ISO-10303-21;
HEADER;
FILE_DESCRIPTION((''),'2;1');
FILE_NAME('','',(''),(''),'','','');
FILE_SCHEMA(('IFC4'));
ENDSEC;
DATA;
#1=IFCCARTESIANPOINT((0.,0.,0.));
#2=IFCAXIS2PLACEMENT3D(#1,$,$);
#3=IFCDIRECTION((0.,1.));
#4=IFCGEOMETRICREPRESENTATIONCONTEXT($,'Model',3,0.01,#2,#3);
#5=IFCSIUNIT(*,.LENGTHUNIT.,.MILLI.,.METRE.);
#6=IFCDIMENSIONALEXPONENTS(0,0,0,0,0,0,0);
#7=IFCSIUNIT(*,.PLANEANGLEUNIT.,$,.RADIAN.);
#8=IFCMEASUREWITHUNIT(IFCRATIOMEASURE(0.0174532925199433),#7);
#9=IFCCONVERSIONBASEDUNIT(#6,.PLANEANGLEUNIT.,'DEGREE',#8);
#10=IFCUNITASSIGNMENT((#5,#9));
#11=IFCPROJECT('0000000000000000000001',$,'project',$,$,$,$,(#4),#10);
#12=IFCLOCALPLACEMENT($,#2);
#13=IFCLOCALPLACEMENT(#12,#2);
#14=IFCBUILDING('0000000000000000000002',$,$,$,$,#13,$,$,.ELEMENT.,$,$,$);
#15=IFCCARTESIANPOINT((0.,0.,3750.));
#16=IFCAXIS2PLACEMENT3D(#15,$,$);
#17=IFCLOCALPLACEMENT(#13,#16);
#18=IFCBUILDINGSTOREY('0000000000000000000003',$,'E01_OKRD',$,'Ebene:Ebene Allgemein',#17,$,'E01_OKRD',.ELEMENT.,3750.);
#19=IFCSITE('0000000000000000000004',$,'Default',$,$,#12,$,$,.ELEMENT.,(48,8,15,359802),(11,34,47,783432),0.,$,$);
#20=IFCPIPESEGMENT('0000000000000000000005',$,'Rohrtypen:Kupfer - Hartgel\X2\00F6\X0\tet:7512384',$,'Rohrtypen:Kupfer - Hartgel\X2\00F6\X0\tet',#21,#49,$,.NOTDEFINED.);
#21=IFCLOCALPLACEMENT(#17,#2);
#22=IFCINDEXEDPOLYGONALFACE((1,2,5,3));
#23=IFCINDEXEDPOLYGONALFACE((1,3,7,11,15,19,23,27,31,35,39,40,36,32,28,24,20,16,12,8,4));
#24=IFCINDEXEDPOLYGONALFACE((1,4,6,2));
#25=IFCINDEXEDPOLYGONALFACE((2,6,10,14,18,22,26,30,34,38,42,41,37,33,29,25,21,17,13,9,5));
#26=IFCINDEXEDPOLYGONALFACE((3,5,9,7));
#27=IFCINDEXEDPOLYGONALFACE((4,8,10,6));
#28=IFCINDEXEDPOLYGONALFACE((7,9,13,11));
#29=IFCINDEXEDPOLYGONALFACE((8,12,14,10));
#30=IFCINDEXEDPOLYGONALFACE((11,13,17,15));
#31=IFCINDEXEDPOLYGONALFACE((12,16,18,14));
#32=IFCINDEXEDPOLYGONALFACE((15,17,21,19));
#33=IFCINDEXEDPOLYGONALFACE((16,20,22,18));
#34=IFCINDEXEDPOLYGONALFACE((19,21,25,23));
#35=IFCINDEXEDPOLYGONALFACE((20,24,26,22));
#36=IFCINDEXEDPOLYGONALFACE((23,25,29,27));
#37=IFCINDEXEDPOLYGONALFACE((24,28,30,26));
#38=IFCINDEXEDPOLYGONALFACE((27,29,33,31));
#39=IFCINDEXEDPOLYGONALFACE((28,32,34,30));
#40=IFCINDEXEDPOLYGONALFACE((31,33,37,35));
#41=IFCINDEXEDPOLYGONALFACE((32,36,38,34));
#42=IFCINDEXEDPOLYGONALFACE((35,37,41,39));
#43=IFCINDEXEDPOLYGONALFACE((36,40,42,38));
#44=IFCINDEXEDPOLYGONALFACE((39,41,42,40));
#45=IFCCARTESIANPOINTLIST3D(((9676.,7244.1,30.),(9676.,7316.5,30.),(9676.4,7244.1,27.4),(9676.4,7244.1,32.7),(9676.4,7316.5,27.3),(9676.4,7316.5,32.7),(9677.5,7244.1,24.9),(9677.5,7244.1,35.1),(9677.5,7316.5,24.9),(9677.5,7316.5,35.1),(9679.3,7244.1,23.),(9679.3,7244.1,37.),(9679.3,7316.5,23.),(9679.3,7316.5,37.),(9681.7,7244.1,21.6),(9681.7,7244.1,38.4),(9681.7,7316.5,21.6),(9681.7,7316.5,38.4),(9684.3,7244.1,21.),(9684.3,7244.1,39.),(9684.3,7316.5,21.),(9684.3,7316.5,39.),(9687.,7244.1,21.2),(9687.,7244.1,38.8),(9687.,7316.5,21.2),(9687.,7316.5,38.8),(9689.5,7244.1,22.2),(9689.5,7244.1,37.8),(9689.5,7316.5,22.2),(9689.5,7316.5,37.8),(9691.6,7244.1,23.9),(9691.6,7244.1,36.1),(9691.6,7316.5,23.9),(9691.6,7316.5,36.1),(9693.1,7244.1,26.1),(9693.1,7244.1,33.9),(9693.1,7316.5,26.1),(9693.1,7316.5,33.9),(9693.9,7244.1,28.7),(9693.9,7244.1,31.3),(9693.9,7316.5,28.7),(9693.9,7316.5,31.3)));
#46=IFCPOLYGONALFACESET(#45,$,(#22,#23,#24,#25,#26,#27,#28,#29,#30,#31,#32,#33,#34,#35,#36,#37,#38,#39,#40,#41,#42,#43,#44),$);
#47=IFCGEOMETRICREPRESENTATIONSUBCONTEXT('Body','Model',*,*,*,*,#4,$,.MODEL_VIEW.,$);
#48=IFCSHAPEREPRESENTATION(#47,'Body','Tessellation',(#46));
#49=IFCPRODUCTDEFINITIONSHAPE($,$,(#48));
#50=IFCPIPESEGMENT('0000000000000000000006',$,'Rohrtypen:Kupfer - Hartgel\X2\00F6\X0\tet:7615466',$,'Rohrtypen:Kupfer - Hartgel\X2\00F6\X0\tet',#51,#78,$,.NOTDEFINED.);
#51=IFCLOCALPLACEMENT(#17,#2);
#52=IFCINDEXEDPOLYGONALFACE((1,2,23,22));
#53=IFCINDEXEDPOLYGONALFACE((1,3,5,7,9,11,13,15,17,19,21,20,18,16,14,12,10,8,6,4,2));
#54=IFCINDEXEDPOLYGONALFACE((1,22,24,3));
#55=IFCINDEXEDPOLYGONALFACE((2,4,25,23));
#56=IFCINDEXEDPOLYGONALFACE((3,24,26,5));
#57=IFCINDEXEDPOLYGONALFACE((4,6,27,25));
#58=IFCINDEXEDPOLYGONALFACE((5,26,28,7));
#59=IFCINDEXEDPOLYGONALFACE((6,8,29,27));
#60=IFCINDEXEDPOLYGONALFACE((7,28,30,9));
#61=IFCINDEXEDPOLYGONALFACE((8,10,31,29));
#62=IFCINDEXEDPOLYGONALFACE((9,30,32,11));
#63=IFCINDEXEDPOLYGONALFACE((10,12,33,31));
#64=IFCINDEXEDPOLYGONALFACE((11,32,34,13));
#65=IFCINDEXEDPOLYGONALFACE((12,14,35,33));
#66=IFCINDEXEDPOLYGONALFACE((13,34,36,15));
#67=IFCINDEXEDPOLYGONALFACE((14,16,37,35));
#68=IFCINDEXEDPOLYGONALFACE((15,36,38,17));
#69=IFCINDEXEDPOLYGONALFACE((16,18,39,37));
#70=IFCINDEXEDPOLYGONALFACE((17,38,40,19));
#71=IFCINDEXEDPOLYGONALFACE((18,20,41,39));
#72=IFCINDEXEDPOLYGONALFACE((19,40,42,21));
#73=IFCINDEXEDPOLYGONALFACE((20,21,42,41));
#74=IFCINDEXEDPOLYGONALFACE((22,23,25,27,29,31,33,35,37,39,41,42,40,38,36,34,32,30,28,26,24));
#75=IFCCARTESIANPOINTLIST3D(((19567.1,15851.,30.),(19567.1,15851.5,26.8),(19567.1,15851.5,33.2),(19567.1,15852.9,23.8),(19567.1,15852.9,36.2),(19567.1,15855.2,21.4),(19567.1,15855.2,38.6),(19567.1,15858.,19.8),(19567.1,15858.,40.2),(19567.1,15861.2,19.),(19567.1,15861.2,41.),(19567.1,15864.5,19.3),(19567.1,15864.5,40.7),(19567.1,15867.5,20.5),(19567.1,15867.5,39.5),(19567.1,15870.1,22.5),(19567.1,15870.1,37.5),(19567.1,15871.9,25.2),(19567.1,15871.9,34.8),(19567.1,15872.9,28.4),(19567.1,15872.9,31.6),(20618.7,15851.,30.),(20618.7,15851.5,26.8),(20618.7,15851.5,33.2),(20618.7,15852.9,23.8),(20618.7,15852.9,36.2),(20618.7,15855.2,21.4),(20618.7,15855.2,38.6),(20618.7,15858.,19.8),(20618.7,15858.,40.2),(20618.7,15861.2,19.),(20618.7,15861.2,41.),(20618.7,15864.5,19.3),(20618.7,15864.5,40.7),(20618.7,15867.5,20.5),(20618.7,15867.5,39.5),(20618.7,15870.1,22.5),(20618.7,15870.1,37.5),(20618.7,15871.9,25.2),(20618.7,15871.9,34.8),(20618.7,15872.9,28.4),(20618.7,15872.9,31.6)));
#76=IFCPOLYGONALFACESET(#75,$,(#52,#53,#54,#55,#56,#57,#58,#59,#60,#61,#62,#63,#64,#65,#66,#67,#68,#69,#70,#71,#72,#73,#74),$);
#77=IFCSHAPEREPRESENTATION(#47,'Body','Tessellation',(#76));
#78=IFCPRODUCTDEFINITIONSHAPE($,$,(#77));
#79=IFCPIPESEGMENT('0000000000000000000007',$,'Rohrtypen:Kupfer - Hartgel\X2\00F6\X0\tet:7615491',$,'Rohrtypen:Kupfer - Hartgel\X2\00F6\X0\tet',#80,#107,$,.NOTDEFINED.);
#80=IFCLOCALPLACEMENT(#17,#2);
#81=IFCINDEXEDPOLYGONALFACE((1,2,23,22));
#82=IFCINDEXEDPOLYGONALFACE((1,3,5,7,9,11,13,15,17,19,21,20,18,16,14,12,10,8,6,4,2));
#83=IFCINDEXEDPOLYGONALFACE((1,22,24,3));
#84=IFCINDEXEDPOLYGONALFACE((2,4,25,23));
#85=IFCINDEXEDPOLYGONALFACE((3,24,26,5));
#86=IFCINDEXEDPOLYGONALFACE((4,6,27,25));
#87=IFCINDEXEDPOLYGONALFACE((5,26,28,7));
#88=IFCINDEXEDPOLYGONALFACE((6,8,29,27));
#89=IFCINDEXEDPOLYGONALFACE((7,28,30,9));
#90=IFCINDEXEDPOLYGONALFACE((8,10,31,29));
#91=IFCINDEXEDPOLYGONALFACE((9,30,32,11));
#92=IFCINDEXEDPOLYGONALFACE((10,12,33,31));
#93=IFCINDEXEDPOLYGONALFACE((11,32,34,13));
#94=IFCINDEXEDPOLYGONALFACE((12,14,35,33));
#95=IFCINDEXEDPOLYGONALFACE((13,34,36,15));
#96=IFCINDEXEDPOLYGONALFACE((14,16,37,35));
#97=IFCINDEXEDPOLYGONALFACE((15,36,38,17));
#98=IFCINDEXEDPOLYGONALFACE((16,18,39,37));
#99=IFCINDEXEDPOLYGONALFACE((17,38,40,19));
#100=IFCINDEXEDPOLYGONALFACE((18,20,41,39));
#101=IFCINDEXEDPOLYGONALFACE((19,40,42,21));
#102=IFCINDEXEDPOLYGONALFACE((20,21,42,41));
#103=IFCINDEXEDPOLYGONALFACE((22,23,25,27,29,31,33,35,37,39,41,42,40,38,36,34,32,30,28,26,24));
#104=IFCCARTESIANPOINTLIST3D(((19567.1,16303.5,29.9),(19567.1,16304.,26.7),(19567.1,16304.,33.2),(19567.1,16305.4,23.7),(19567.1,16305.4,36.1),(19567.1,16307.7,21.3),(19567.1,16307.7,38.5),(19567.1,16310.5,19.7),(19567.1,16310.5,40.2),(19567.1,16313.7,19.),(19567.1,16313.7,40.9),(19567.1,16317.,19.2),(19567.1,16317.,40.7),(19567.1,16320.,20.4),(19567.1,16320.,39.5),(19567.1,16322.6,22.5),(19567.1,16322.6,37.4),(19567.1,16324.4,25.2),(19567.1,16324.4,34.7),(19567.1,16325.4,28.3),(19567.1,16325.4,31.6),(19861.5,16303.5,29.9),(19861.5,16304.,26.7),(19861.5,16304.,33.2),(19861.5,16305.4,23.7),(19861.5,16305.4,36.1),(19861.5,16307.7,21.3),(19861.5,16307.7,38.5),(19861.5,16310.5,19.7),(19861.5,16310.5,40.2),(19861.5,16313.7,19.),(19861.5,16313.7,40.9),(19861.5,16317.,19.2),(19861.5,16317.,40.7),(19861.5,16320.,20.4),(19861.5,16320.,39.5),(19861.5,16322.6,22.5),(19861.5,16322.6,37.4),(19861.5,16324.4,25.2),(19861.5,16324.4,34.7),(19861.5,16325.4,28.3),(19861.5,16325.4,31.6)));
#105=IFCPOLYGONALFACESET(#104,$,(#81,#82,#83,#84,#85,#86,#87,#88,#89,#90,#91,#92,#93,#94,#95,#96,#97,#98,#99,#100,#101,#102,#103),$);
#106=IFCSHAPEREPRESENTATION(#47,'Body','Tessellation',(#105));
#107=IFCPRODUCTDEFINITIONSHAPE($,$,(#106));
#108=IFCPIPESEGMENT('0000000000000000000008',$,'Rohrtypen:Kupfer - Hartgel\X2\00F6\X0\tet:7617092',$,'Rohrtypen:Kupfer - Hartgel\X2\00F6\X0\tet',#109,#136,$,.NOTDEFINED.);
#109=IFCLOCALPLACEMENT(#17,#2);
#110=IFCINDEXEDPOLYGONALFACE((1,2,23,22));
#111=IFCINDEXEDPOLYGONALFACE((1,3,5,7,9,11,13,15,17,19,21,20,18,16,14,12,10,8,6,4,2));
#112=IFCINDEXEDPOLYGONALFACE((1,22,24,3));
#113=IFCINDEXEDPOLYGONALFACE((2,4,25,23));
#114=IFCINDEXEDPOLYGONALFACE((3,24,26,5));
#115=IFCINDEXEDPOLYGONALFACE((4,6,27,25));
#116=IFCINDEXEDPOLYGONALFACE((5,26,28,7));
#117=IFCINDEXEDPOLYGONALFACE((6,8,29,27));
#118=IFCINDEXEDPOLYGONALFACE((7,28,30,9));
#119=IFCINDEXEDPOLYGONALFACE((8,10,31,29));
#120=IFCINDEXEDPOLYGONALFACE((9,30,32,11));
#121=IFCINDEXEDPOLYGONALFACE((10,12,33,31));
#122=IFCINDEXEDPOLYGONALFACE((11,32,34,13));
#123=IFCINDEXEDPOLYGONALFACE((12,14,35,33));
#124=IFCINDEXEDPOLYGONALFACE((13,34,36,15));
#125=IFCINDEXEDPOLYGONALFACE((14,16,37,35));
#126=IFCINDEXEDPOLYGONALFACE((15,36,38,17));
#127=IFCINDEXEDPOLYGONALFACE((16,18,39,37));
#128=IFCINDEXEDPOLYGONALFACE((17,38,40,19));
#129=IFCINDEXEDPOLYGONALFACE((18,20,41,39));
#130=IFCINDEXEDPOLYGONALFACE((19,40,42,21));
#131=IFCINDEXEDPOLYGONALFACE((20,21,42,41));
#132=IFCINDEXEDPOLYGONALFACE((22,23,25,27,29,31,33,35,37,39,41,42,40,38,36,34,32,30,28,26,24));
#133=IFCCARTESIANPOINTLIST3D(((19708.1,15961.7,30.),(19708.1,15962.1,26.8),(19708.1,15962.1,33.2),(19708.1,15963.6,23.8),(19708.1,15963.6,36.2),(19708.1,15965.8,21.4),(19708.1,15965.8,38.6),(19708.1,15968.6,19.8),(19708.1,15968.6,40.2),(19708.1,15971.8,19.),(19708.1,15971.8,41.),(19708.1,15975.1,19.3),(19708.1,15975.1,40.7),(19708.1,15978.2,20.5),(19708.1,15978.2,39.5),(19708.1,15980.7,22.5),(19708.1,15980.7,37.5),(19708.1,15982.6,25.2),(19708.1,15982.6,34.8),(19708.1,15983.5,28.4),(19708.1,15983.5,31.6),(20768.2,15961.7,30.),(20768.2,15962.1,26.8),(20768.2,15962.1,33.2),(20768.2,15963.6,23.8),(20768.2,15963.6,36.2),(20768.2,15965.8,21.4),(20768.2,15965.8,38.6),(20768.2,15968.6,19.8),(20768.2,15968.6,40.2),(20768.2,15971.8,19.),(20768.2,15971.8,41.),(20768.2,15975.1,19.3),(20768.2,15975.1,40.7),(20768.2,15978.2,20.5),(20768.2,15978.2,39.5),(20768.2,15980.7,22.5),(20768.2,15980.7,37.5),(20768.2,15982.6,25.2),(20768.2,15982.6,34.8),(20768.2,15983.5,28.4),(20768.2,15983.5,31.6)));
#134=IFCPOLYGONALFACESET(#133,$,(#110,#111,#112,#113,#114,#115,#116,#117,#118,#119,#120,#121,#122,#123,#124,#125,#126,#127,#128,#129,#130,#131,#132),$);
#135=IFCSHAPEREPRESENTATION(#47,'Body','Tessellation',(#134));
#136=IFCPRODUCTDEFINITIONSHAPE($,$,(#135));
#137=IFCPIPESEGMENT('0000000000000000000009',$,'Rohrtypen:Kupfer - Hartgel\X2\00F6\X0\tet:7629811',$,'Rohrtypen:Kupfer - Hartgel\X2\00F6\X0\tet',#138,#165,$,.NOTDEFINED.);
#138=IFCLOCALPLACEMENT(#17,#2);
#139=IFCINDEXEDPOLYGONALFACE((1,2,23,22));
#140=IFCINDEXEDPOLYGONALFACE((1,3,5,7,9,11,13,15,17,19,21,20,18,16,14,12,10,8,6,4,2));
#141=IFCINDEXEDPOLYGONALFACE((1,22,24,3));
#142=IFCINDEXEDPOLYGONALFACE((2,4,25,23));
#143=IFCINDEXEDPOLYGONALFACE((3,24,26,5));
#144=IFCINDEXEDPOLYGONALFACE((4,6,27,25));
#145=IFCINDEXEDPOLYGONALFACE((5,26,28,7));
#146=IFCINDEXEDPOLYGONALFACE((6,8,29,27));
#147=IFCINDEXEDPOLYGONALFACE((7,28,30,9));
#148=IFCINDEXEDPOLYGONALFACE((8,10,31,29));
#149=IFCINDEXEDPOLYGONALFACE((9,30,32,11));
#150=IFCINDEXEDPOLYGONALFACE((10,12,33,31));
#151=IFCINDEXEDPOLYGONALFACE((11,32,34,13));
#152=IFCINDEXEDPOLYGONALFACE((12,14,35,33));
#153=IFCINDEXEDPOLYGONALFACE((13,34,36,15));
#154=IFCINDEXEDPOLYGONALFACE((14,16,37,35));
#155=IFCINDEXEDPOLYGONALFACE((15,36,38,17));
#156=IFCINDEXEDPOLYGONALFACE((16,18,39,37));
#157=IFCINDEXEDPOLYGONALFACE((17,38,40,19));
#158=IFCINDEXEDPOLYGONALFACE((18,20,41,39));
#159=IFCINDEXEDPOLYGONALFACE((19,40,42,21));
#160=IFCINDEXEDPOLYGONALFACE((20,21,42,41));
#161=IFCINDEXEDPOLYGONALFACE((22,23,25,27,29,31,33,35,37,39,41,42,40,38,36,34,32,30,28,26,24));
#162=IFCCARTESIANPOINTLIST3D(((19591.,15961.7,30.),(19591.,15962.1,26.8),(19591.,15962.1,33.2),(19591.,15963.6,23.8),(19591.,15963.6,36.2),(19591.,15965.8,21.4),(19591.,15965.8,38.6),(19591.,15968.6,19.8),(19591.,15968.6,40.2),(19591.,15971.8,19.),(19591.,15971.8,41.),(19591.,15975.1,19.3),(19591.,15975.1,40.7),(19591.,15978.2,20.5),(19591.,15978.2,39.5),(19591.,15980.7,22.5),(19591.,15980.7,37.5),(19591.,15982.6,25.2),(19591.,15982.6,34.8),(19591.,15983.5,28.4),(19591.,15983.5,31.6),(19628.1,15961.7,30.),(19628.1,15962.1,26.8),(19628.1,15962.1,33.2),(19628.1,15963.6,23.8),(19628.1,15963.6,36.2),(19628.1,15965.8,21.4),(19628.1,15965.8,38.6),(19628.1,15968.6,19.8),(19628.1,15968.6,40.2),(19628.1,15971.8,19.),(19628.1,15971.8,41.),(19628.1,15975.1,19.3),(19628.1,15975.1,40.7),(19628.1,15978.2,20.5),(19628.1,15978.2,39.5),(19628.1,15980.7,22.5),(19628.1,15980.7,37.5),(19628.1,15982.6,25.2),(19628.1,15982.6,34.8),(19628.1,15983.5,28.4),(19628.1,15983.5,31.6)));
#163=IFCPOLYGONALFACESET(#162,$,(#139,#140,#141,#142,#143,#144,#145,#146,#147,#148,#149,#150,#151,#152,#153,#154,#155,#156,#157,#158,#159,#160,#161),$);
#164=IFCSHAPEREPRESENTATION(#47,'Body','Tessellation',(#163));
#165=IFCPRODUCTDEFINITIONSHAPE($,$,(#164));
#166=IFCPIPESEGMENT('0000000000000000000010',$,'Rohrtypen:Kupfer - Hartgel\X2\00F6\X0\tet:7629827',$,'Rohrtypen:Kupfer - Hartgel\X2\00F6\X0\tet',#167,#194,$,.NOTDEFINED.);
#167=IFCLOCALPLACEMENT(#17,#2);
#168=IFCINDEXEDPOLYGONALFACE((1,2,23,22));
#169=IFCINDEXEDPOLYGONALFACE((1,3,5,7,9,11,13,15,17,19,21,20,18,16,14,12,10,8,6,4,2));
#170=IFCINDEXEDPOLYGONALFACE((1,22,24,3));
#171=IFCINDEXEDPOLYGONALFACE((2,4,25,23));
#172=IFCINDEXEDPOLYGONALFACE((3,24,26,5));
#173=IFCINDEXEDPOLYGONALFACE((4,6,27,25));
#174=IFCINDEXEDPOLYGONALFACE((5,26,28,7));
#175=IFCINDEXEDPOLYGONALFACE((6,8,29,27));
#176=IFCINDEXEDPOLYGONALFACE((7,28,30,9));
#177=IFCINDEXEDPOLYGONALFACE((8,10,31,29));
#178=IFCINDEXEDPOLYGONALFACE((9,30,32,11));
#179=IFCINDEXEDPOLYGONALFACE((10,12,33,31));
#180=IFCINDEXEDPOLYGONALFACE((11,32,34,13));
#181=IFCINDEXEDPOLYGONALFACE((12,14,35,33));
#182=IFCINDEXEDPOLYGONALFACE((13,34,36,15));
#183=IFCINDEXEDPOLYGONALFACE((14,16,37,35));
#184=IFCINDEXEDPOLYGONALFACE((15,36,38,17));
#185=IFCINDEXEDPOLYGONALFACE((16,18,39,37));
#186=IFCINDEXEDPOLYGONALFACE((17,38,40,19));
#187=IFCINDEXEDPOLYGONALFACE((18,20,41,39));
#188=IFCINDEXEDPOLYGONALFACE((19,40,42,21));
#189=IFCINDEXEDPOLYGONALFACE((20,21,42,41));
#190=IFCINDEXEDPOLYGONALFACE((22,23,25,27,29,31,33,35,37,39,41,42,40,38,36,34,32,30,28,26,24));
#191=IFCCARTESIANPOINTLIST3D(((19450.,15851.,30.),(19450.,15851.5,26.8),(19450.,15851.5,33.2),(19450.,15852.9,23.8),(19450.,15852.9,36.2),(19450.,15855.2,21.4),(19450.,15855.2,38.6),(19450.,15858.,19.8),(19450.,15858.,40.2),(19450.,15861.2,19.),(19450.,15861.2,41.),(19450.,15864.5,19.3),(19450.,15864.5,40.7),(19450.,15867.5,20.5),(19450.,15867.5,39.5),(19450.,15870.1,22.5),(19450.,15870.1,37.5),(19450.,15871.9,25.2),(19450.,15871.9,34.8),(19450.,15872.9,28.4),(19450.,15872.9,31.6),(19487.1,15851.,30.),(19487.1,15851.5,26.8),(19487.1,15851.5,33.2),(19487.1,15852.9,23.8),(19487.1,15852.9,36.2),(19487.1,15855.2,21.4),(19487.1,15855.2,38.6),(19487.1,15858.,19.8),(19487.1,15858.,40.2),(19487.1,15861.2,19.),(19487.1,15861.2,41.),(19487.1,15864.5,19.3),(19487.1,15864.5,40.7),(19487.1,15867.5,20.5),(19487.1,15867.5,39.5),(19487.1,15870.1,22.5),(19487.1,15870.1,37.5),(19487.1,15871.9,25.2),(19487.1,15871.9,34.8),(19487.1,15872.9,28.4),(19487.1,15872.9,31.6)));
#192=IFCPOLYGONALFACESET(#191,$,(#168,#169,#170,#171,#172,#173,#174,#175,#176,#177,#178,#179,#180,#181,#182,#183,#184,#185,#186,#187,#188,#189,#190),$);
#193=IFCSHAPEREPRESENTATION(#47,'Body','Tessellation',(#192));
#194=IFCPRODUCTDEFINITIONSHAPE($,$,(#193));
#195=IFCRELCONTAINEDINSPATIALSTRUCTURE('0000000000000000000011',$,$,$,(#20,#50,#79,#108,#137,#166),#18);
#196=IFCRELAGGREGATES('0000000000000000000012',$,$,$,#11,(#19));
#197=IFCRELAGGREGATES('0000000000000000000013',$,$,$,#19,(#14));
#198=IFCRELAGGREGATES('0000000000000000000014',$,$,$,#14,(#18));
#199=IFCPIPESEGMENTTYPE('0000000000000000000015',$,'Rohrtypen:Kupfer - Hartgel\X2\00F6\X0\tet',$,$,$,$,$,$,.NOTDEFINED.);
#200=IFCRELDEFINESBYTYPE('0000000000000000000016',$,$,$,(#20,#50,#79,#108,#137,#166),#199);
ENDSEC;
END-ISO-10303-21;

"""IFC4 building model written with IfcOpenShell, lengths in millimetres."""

from ifc_helpers import new_model, entity, si_unit, converted_unit, direction, frame, frame_2d, origin, origin_2d_with_axis, place, context, subcontext, project, spatial, circle, extrude, type_object, element, save


model = new_model("IFC4")

# Units and contexts
model_context = context("Model", 3, precision=0.01, world=origin(), true_north=direction((0.0, 1.0)))
body_context = subcontext(model_context, "Body", "Model", "MODEL_VIEW")
ifc_project = project(units=[si_unit("LENGTHUNIT", "METRE", prefix="MILLI"), converted_unit("PLANEANGLEUNIT", "DEGREE", entity("IfcRatioMeasure", 0.0174532925199433), si_unit("PLANEANGLEUNIT", "RADIAN"), dimensions=[0, 0, 0, 0, 0, 0, 0])], contexts=[model_context])

# Site, building, storey
site_placement = place(None, origin())
site = spatial("IfcSite", under=ifc_project, at=site_placement, Name="Default", CompositionType="ELEMENT", RefLatitude=(48, 8, 15, 359802), RefLongitude=(11, 34, 47, 783432), RefElevation=0.0)
building_placement = place(site_placement, origin())
building = spatial("IfcBuilding", under=site, at=building_placement, CompositionType="ELEMENT")
storey_placement = place(building_placement, frame((0.0, 0.0, 3750.0)))
storey = spatial("IfcBuildingStorey", under=building, at=storey_placement, Name="E01_OKRD", ObjectType="Ebene:Ebene Allgemein", LongName="E01_OKRD", CompositionType="ELEMENT", Elevation=3750.0)

# Pipe segments
pipe_segment_type = type_object("IfcPipeSegmentType", Name="Rohrtypen:Kupfer - Hartgelötet", PredefinedType="NOTDEFINED")
pipe_segment_1_placement = place(storey_placement, frame((9674.4, 7244.1, 19.4)))
element("IfcPipeSegment", 1, at=pipe_segment_1_placement, inside=storey, type_object=pipe_segment_type, Name="Rohrtypen:Kupfer - Hartgelötet:7512384", ObjectType="Rohrtypen:Kupfer - Hartgelötet", PredefinedType="NOTDEFINED", context=body_context, shape_type="SweptSolid", body=[
    extrude(circle(Radius=9.0, at=origin_2d_with_axis()), frame((10.6, 72.4, 10.6), z_axis=(0.0, -1.0, 0.000084), x_axis=(-1.0, 0.0, 0.0)), (0.0, 0.0, 1.0), 72.4),
])
pipe_segment_2_placement = place(storey_placement, frame((19567.1, 15849.4, 17.4)))
element("IfcPipeSegment", 2, at=pipe_segment_2_placement, inside=storey, type_object=pipe_segment_type, Name="Rohrtypen:Kupfer - Hartgelötet:7615466", ObjectType="Rohrtypen:Kupfer - Hartgelötet", PredefinedType="NOTDEFINED", context=body_context, shape_type="SweptSolid", body=[
    extrude(circle(Radius=11.0, at=origin_2d_with_axis()), frame((0.0, 12.6, 12.6), z_axis=(1.0, 0.0, 0.0), x_axis=(0.0, -1.0, 0.0)), (0.0, 0.0, 1.0), 1051.6),
])
pipe_segment_3_placement = place(storey_placement, frame((19567.1, 16301.9, 17.3)))
element("IfcPipeSegment", 3, at=pipe_segment_3_placement, inside=storey, type_object=pipe_segment_type, Name="Rohrtypen:Kupfer - Hartgelötet:7615491", ObjectType="Rohrtypen:Kupfer - Hartgelötet", PredefinedType="NOTDEFINED", context=body_context, shape_type="SweptSolid", body=[
    extrude(circle(Radius=11.0, at=frame_2d((0.0, 0.0), x_axis=(1.0, 0.0))), frame((0.0, 12.6, 12.6), z_axis=(1.0, 0.0, 0.0), x_axis=(0.0, -1.0, 0.0)), (0.0, 0.0, 1.0), 294.4),
])
pipe_segment_4_placement = place(storey_placement, frame((19708.1, 15960.1, 17.4)))
element("IfcPipeSegment", 4, at=pipe_segment_4_placement, inside=storey, type_object=pipe_segment_type, Name="Rohrtypen:Kupfer - Hartgelötet:7617092", ObjectType="Rohrtypen:Kupfer - Hartgelötet", PredefinedType="NOTDEFINED", context=body_context, shape_type="SweptSolid", body=[
    extrude(circle(Radius=11.0, at=origin_2d_with_axis()), frame((0.0, 12.6, 12.6), z_axis=(1.0, 0.0, 0.0), x_axis=(0.0, -1.0, 0.0)), (0.0, 0.0, 1.0), 1060.1),
])
pipe_segment_5_placement = place(storey_placement, frame((19591.0, 15960.1, 17.4)))
element("IfcPipeSegment", 5, at=pipe_segment_5_placement, inside=storey, type_object=pipe_segment_type, Name="Rohrtypen:Kupfer - Hartgelötet:7629811", ObjectType="Rohrtypen:Kupfer - Hartgelötet", PredefinedType="NOTDEFINED", context=body_context, shape_type="SweptSolid", body=[
    extrude(circle(Radius=11.0, at=origin_2d_with_axis()), frame((0.0, 12.6, 12.6), z_axis=(1.0, 0.0, 0.0), x_axis=(0.0, -1.0, 0.0)), (0.0, 0.0, 1.0), 37.1),
])
pipe_segment_6_placement = place(storey_placement, frame((19450.0, 15849.4, 17.4)))
element("IfcPipeSegment", 6, at=pipe_segment_6_placement, inside=storey, type_object=pipe_segment_type, Name="Rohrtypen:Kupfer - Hartgelötet:7629827", ObjectType="Rohrtypen:Kupfer - Hartgelötet", PredefinedType="NOTDEFINED", context=body_context, shape_type="SweptSolid", body=[
    extrude(circle(Radius=11.0, at=origin_2d_with_axis()), frame((0.0, 12.6, 12.6), z_axis=(1.0, 0.0, 0.0), x_axis=(0.0, -1.0, 0.0)), (0.0, 0.0, 1.0), 37.1),
])

save(model, "model.ifc")
